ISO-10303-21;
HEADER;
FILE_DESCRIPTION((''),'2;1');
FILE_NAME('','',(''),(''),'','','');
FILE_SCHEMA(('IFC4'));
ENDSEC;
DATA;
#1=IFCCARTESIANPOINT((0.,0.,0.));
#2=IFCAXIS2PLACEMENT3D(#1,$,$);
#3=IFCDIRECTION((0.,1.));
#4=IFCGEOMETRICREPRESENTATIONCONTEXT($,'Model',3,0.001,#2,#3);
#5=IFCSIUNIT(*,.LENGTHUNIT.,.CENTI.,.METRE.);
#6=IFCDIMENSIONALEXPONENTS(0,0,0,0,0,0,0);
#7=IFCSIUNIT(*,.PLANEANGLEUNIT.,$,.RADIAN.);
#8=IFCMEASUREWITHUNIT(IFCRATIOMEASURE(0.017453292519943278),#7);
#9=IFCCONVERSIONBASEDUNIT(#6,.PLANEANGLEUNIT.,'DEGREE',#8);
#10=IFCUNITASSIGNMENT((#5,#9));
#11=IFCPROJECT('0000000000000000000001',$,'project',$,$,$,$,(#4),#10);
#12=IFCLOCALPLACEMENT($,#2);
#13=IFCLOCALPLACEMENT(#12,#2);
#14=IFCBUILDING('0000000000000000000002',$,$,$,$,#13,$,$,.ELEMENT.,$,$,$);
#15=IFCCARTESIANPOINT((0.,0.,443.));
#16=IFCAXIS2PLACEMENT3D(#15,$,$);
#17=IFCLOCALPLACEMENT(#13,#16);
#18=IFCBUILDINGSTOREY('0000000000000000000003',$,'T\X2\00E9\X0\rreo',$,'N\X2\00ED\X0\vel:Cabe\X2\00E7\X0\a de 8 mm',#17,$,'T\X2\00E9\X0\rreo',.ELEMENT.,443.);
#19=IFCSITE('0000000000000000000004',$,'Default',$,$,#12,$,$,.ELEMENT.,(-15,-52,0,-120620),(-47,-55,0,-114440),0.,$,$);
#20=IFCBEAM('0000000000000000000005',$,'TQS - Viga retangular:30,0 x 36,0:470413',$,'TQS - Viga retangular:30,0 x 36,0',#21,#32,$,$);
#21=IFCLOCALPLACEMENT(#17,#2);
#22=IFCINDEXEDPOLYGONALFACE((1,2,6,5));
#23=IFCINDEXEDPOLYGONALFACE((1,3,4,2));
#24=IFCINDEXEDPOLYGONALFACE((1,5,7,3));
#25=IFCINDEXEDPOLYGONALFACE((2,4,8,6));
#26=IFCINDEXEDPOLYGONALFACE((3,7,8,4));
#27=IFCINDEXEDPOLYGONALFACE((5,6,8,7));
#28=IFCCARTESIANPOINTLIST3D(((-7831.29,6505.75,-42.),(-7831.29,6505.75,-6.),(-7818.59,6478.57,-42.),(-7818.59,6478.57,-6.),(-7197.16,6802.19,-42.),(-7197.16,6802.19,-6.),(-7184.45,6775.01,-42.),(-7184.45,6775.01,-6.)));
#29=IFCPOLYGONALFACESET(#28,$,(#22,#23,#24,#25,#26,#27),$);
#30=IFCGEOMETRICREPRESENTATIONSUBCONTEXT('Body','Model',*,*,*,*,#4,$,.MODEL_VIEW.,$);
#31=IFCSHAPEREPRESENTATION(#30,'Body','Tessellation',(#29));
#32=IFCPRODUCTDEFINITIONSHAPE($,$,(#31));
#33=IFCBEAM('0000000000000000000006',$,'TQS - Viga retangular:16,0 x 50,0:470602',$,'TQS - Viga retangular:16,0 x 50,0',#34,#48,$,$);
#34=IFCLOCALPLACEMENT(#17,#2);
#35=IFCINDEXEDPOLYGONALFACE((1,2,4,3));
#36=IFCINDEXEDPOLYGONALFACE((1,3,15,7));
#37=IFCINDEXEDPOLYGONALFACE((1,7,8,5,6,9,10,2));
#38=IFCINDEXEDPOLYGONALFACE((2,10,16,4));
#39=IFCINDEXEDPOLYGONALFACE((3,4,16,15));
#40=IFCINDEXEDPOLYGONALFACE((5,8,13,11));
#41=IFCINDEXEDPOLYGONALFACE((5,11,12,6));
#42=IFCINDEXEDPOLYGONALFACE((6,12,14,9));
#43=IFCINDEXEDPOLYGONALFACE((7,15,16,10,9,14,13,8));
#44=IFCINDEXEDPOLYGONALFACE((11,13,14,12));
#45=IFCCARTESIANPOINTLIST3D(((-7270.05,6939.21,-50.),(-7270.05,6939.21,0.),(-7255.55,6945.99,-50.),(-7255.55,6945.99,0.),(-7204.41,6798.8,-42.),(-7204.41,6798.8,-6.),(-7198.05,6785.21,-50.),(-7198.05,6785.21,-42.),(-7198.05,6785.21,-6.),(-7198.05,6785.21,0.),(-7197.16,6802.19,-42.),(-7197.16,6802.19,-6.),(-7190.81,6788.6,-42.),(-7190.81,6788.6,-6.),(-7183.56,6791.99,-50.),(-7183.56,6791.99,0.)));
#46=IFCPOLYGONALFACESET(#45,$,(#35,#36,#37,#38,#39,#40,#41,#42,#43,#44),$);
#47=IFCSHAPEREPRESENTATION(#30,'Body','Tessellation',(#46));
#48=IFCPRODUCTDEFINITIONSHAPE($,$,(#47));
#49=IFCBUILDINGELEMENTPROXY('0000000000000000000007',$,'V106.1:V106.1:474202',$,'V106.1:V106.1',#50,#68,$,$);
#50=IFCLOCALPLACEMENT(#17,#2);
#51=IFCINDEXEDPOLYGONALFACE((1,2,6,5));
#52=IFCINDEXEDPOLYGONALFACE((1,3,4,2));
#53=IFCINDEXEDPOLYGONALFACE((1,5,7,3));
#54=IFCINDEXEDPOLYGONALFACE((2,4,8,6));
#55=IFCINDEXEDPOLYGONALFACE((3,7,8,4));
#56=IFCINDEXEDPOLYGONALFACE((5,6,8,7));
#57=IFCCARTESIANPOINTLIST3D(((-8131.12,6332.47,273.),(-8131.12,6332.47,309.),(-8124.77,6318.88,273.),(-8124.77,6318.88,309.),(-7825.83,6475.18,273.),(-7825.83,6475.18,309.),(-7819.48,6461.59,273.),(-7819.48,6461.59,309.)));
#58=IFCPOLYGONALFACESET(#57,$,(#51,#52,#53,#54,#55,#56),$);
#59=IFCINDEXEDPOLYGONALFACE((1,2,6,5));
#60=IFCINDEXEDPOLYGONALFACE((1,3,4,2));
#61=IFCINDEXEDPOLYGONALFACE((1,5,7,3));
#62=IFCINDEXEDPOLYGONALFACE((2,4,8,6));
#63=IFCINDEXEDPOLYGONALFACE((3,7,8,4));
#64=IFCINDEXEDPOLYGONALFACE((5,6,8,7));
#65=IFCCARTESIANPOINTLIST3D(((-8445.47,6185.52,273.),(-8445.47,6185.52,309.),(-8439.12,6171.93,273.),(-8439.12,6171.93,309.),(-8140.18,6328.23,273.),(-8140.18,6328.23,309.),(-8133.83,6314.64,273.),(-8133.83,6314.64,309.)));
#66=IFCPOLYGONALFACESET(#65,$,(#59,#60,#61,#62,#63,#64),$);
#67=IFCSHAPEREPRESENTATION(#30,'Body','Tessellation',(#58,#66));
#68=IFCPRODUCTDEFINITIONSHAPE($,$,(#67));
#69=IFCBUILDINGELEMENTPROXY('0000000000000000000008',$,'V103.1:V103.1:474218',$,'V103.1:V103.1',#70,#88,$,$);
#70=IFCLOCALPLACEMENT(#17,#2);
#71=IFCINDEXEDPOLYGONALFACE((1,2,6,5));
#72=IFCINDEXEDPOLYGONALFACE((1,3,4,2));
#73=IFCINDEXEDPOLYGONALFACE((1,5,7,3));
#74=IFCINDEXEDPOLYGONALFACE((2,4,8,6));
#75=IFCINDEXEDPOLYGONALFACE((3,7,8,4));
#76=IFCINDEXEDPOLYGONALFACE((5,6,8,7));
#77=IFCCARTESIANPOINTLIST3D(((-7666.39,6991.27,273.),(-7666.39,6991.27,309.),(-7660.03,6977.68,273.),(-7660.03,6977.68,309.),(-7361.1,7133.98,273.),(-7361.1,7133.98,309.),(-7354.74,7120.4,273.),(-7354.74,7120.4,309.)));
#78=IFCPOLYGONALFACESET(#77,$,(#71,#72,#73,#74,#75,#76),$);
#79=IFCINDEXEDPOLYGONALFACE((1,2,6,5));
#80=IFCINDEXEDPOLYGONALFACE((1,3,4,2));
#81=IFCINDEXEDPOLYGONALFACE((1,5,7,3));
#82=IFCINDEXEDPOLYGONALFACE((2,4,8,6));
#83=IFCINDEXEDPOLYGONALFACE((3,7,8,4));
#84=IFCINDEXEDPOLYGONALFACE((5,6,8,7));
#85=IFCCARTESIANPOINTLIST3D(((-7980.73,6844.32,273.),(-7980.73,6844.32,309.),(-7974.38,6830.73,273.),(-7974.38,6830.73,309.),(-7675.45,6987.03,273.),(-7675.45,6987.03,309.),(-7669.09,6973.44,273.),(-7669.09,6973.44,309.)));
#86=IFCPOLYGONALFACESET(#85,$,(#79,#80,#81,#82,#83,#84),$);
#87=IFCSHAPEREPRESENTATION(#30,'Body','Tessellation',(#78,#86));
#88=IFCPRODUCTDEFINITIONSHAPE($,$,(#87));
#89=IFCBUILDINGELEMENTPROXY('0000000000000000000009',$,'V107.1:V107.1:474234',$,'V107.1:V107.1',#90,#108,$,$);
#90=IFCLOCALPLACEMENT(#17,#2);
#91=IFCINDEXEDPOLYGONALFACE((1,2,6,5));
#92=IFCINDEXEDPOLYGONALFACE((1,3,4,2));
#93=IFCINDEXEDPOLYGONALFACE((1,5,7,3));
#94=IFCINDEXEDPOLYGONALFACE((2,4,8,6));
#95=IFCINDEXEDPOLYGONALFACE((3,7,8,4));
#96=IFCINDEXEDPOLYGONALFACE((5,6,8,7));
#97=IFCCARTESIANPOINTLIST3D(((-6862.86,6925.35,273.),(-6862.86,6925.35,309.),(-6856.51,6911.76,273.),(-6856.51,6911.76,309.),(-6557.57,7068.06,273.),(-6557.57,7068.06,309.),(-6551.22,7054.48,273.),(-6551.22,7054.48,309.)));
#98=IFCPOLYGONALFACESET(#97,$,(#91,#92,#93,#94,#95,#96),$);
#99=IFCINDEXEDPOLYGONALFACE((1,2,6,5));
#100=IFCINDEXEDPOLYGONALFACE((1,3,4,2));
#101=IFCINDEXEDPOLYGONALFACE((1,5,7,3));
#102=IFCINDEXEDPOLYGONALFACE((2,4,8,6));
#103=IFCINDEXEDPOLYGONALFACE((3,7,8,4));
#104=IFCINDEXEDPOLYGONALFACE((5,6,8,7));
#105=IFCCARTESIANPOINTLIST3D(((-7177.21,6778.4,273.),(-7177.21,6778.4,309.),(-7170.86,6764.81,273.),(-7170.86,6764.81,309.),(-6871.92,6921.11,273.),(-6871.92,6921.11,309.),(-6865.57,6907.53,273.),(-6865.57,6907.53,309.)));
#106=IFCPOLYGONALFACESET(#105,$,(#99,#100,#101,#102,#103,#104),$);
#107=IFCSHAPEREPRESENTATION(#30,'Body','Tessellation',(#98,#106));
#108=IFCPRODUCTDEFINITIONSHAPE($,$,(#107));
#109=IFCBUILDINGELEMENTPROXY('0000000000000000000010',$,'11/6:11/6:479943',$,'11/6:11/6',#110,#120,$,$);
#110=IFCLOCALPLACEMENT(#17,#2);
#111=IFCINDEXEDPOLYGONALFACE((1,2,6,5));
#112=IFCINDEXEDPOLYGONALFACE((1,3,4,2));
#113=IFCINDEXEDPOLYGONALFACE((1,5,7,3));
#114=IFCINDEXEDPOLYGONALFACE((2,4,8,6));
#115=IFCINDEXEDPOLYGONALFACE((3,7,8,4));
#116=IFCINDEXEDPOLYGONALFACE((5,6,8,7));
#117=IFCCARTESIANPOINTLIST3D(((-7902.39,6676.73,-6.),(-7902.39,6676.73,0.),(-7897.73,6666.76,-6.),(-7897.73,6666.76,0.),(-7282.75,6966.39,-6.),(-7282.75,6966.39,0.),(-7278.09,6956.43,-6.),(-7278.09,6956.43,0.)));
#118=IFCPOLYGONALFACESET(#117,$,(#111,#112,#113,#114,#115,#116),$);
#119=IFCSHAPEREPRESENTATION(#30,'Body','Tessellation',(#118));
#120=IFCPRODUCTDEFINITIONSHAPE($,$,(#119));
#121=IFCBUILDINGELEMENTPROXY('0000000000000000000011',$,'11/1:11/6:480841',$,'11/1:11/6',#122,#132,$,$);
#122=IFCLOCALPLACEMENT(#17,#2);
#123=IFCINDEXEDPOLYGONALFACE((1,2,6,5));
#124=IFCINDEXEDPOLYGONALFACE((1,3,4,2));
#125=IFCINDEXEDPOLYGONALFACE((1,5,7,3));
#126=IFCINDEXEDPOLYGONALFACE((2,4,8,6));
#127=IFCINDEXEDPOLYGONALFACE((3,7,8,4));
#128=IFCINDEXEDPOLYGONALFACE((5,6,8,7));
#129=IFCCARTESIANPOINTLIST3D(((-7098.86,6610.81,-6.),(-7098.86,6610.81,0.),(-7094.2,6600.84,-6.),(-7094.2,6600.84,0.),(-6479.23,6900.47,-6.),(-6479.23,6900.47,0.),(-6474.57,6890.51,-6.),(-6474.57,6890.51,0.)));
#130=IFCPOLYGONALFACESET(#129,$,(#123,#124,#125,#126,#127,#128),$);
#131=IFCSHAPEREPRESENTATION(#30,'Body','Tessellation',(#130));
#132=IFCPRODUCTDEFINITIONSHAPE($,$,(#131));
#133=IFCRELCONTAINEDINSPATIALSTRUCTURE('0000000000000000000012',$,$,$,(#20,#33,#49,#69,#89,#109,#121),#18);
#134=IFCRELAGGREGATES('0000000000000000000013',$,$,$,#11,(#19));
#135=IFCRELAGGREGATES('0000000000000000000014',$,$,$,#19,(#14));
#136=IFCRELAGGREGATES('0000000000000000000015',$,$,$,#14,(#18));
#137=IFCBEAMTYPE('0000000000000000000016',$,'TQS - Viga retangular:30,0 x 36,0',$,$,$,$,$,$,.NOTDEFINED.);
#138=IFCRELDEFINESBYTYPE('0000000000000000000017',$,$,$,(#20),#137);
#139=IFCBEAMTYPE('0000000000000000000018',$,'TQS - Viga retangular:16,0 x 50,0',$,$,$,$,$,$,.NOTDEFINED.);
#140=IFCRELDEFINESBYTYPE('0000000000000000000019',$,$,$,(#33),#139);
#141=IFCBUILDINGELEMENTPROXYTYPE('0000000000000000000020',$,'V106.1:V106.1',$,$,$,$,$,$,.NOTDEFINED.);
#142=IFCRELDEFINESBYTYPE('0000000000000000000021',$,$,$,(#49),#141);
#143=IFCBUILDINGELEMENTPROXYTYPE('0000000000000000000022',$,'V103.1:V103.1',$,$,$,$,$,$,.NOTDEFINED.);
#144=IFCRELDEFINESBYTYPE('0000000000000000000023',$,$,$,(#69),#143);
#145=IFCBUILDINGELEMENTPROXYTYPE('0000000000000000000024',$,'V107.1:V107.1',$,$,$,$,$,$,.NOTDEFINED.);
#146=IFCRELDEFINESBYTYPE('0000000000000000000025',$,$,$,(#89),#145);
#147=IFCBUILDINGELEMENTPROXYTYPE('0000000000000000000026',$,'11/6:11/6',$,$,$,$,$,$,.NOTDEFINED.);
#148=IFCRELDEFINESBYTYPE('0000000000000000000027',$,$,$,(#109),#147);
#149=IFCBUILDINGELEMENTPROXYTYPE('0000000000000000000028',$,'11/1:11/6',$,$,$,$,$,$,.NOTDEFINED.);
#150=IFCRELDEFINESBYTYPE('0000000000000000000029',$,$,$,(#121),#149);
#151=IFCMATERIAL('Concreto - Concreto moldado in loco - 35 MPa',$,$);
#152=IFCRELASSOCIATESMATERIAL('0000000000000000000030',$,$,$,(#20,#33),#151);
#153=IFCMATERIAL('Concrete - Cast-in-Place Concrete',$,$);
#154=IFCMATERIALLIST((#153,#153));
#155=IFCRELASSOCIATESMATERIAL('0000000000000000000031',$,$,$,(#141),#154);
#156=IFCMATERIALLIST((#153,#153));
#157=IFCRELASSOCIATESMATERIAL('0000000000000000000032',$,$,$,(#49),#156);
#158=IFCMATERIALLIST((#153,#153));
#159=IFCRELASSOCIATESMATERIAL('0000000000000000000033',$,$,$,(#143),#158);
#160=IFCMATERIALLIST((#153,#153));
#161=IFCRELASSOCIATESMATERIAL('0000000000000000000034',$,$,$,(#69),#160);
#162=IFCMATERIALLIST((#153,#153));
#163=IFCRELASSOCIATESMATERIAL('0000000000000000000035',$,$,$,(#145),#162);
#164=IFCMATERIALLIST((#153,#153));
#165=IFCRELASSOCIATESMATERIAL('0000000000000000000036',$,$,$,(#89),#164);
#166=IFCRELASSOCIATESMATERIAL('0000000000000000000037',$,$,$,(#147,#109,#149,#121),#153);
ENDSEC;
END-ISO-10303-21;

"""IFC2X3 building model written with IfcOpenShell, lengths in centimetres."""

from ifc_helpers import new_model, entity, si_unit, converted_unit, direction, frame, frame_2d, origin, origin_2d_with_axis, place, context, subcontext, project, spatial, polyline, rectangle, extrude, boolean, clip, bounded_halfspace, source, transform, mapped, material, material_list, type_object, type_shapes, element, save


model = new_model("IFC2X3")

# Units and contexts
model_context = context("Model", 3, precision=0.001, world=origin(), true_north=direction((0.0, 1.0)))
body_context = subcontext(model_context, "Body", "Model", "MODEL_VIEW")
ifc_project = project(units=[si_unit("LENGTHUNIT", "METRE", prefix="CENTI"), converted_unit("PLANEANGLEUNIT", "DEGREE", entity("IfcRatioMeasure", 0.017453292519943278), si_unit("PLANEANGLEUNIT", "RADIAN"), dimensions=[0, 0, 0, 0, 0, 0, 0])], contexts=[model_context])

# Site, building, storey
site_placement = place(None, origin())
site = spatial("IfcSite", under=ifc_project, at=site_placement, Name="Default", CompositionType="ELEMENT", RefLatitude=(-15, -52, 0, -120620), RefLongitude=(-47, -55, 0, -114440), RefElevation=0.0)
building_placement = place(site_placement, origin())
building = spatial("IfcBuilding", under=site, at=building_placement, CompositionType="ELEMENT")
storey_placement = place(building_placement, frame((0.0, 0.0, 443.0)))
storey = spatial("IfcBuildingStorey", under=building, at=storey_placement, Name="Térreo", ObjectType="Nível:Cabeça de 8 mm", LongName="Térreo", CompositionType="ELEMENT", Elevation=443.0)

# Beams
ifc_material_1 = material(Name="Concreto - Concreto moldado in loco - 35 MPa")
beam_type_1 = type_object("IfcBeamType", Name="TQS - Viga retangular:30,0 x 36,0", PredefinedType="NOTDEFINED")
beam_1_placement = place(storey_placement, frame((-7824.94, 6492.16, -6.0), z_axis=(0.0, 0.0, 1.0), x_axis=(0.905902, 0.423488, 0.0)))
element("IfcBeam", 1, at=beam_1_placement, inside=storey, type_object=beam_type_1, material=ifc_material_1, Name="TQS - Viga retangular:30,0 x 36,0:470413", ObjectType="TQS - Viga retangular:30,0 x 36,0", context=body_context, shape_type="SweptSolid", body=[
    extrude(rectangle(XDim=36.0, YDim=30.0, at=frame_2d((0.0, 0.0), x_axis=(1.0, 0.0))), frame((0.0, 0.0, -18.0), z_axis=(1.0, 0.0, 0.0), x_axis=(0.0, 0.0, -1.0)), (0.0, 0.0, 1.0), 700.0),
])
beam_type_2 = type_object("IfcBeamType", Name="TQS - Viga retangular:16,0 x 50,0", PredefinedType="NOTDEFINED")
beam_2_placement = place(storey_placement, frame((-7190.81, 6788.6, 0.0), z_axis=(0.0, 0.0, 1.0), x_axis=(-0.423488, 0.905902, 0.0)))
element("IfcBeam", 2, at=beam_2_placement, inside=storey, type_object=beam_type_2, material=ifc_material_1, Name="TQS - Viga retangular:16,0 x 50,0:470602", ObjectType="TQS - Viga retangular:16,0 x 50,0", context=body_context, shape_type="SweptSolid", body=[
    boolean("DIFFERENCE", clip(extrude(rectangle(XDim=50.0, YDim=16.0, at=frame_2d((0.0, 0.0), x_axis=(1.0, 0.0))), frame((0.0, 0.0, -25.0), z_axis=(1.0, 0.0, 0.0), x_axis=(0.0, 0.0, -1.0)), (0.0, 0.0, 1.0), 170.0), bounded_halfspace(frame((15.0, 0.0, -42.0), z_axis=(-1.0, 0.0, 0.0), x_axis=(0.0, 1.0, 0.0)), False, frame((0.0, 0.0, -25.0), z_axis=(1.0, 0.0, 0.0), x_axis=(0.0, 0.0, -1.0)), polyline([(17.0, 0.0), (-19.0, 0.0), (-19.0, 8.0), (-9.0, 8.0), (17.0, 8.0), (17.0, 0.0)]))), extrude(rectangle(XDim=36.0, YDim=8.0, at=frame_2d((0.0, 0.0), x_axis=(0.0, 1.0))), frame((0.0, 4.0, -24.0), z_axis=(-1.0, 0.0, 0.0), x_axis=(0.0, -1.0, 0.0)), (0.0, 0.0, -1.0), 15.0)),
])

# Building element proxies
ifc_material_2 = material(Name="Concrete - Cast-in-Place Concrete")
ifc_material_list_1 = material_list([ifc_material_2, ifc_material_2])
ifc_material_list_2 = material_list([ifc_material_2, ifc_material_2])
building_element_proxy_type_1 = type_object("IfcBuildingElementProxyType", Name="V106.1:V106.1", PredefinedType="NOTDEFINED", material=ifc_material_list_2)
shared_shape_1 = source(origin(), body_context, "Body", "SweptSolid", [
    extrude(rectangle(XDim=15.0, YDim=337.0, at=origin_2d_with_axis()), frame((470.17, 225.1, 0.0), z_axis=(0.0, 0.0, 1.0), x_axis=(-0.423488, 0.905902, 0.0)), (0.0, 0.0, 1.0), 36.0),
    extrude(rectangle(XDim=337.0, YDim=15.0, at=frame_2d((0.0, 0.0), x_axis=(1.0, 0.0))), frame((155.82, 78.15, 0.0), z_axis=(0.0, 0.0, 1.0), x_axis=(-0.905902, -0.423488, 0.0)), (0.0, 0.0, 1.0), 36.0),
])
type_shapes(building_element_proxy_type_1, [shared_shape_1])
proxy_1_placement = place(storey_placement, frame((-8445.47, 6171.93, 273.0)))
element("IfcBuildingElementProxy", 3, at=proxy_1_placement, inside=storey, type_object=building_element_proxy_type_1, material=ifc_material_list_1, Name="V106.1:V106.1:474202", ObjectType="V106.1:V106.1", context=body_context, shape_type="MappedRepresentation", body=[
    mapped(shared_shape_1, transform((0.0, 0.0, 0.0), scale=1.0)),
])
ifc_material_list_3 = material_list([ifc_material_2, ifc_material_2])
ifc_material_list_4 = material_list([ifc_material_2, ifc_material_2])
building_element_proxy_type_2 = type_object("IfcBuildingElementProxyType", Name="V103.1:V103.1", PredefinedType="NOTDEFINED", material=ifc_material_list_4)
shared_shape_2 = source(origin(), body_context, "Body", "SweptSolid", [
    extrude(rectangle(XDim=15.0, YDim=337.0, at=frame_2d((0.0, 0.0), x_axis=(1.0, 0.0))), frame((470.17, 225.1, 0.0), z_axis=(0.0, 0.0, 1.0), x_axis=(-0.423488, 0.905902, 0.0)), (0.0, 0.0, 1.0), 36.0),
    extrude(rectangle(XDim=337.0, YDim=15.0, at=frame_2d((0.0, 0.0), x_axis=(1.0, 0.0))), frame((155.82, 78.15, 0.0), z_axis=(0.0, 0.0, 1.0), x_axis=(-0.905902, -0.423488, 0.0)), (0.0, 0.0, 1.0), 36.0),
])
type_shapes(building_element_proxy_type_2, [shared_shape_2])
proxy_2_placement = place(storey_placement, frame((-7980.73, 6830.73, 273.0)))
element("IfcBuildingElementProxy", 4, at=proxy_2_placement, inside=storey, type_object=building_element_proxy_type_2, material=ifc_material_list_3, Name="V103.1:V103.1:474218", ObjectType="V103.1:V103.1", context=body_context, shape_type="MappedRepresentation", body=[
    mapped(shared_shape_2, transform((0.0, 0.0, 0.0), scale=1.0)),
])
ifc_material_list_5 = material_list([ifc_material_2, ifc_material_2])
ifc_material_list_6 = material_list([ifc_material_2, ifc_material_2])
building_element_proxy_type_3 = type_object("IfcBuildingElementProxyType", Name="V107.1:V107.1", PredefinedType="NOTDEFINED", material=ifc_material_list_6)
shared_shape_3 = source(origin(), body_context, "Body", "SweptSolid", [
    extrude(rectangle(XDim=15.0, YDim=337.0, at=frame_2d((0.0, 0.0), x_axis=(1.0, 0.0))), frame((470.17, 225.1, 0.0), z_axis=(0.0, 0.0, 1.0), x_axis=(-0.423488, 0.905902, 0.0)), (0.0, 0.0, 1.0), 36.0),
    extrude(rectangle(XDim=337.0, YDim=15.0, at=frame_2d((0.0, 0.0), x_axis=(1.0, 0.0))), frame((155.82, 78.15, 0.0), z_axis=(0.0, 0.0, 1.0), x_axis=(-0.905902, -0.423488, 0.0)), (0.0, 0.0, 1.0), 36.0),
])
type_shapes(building_element_proxy_type_3, [shared_shape_3])
proxy_3_placement = place(storey_placement, frame((-7177.21, 6764.81, 273.0)))
element("IfcBuildingElementProxy", 5, at=proxy_3_placement, inside=storey, type_object=building_element_proxy_type_3, material=ifc_material_list_5, Name="V107.1:V107.1:474234", ObjectType="V107.1:V107.1", context=body_context, shape_type="MappedRepresentation", body=[
    mapped(shared_shape_3, transform((0.0, 0.0, 0.0), scale=1.0)),
])
building_element_proxy_type_4 = type_object("IfcBuildingElementProxyType", Name="11/6:11/6", PredefinedType="NOTDEFINED", material=ifc_material_2)
shared_shape_4 = source(origin(), body_context, "Body", "SweptSolid", [
    extrude(rectangle(XDim=11.0, YDim=684.0, at=origin_2d_with_axis()), frame((312.15, 149.82, 0.0), z_axis=(0.0, 0.0, 1.0), x_axis=(0.423488, -0.905902, 0.0)), (0.0, 0.0, 1.0), 6.0),
])
type_shapes(building_element_proxy_type_4, [shared_shape_4])
proxy_4_placement = place(storey_placement, frame((-7902.39, 6666.76, -6.0)))
element("IfcBuildingElementProxy", 6, at=proxy_4_placement, inside=storey, type_object=building_element_proxy_type_4, material=ifc_material_2, Name="11/6:11/6:479943", ObjectType="11/6:11/6", context=body_context, shape_type="MappedRepresentation", body=[
    mapped(shared_shape_4, transform((0.0, 0.0, 0.0), scale=1.0)),
])
building_element_proxy_type_5 = type_object("IfcBuildingElementProxyType", Name="11/1:11/6", PredefinedType="NOTDEFINED", material=ifc_material_2)
shared_shape_5 = source(origin(), body_context, "Body", "SweptSolid", [
    extrude(rectangle(XDim=11.0, YDim=684.0, at=origin_2d_with_axis()), frame((312.15, 149.82, 0.0), z_axis=(0.0, 0.0, 1.0), x_axis=(0.423488, -0.905902, 0.0)), (0.0, 0.0, 1.0), 6.0),
])
type_shapes(building_element_proxy_type_5, [shared_shape_5])
proxy_5_placement = place(storey_placement, frame((-7098.86, 6600.84, -6.0)))
element("IfcBuildingElementProxy", 7, at=proxy_5_placement, inside=storey, type_object=building_element_proxy_type_5, material=ifc_material_2, Name="11/1:11/6:480841", ObjectType="11/1:11/6", context=body_context, shape_type="MappedRepresentation", body=[
    mapped(shared_shape_5, transform((0.0, 0.0, 0.0), scale=1.0)),
])

save(model, "model.ifc")
